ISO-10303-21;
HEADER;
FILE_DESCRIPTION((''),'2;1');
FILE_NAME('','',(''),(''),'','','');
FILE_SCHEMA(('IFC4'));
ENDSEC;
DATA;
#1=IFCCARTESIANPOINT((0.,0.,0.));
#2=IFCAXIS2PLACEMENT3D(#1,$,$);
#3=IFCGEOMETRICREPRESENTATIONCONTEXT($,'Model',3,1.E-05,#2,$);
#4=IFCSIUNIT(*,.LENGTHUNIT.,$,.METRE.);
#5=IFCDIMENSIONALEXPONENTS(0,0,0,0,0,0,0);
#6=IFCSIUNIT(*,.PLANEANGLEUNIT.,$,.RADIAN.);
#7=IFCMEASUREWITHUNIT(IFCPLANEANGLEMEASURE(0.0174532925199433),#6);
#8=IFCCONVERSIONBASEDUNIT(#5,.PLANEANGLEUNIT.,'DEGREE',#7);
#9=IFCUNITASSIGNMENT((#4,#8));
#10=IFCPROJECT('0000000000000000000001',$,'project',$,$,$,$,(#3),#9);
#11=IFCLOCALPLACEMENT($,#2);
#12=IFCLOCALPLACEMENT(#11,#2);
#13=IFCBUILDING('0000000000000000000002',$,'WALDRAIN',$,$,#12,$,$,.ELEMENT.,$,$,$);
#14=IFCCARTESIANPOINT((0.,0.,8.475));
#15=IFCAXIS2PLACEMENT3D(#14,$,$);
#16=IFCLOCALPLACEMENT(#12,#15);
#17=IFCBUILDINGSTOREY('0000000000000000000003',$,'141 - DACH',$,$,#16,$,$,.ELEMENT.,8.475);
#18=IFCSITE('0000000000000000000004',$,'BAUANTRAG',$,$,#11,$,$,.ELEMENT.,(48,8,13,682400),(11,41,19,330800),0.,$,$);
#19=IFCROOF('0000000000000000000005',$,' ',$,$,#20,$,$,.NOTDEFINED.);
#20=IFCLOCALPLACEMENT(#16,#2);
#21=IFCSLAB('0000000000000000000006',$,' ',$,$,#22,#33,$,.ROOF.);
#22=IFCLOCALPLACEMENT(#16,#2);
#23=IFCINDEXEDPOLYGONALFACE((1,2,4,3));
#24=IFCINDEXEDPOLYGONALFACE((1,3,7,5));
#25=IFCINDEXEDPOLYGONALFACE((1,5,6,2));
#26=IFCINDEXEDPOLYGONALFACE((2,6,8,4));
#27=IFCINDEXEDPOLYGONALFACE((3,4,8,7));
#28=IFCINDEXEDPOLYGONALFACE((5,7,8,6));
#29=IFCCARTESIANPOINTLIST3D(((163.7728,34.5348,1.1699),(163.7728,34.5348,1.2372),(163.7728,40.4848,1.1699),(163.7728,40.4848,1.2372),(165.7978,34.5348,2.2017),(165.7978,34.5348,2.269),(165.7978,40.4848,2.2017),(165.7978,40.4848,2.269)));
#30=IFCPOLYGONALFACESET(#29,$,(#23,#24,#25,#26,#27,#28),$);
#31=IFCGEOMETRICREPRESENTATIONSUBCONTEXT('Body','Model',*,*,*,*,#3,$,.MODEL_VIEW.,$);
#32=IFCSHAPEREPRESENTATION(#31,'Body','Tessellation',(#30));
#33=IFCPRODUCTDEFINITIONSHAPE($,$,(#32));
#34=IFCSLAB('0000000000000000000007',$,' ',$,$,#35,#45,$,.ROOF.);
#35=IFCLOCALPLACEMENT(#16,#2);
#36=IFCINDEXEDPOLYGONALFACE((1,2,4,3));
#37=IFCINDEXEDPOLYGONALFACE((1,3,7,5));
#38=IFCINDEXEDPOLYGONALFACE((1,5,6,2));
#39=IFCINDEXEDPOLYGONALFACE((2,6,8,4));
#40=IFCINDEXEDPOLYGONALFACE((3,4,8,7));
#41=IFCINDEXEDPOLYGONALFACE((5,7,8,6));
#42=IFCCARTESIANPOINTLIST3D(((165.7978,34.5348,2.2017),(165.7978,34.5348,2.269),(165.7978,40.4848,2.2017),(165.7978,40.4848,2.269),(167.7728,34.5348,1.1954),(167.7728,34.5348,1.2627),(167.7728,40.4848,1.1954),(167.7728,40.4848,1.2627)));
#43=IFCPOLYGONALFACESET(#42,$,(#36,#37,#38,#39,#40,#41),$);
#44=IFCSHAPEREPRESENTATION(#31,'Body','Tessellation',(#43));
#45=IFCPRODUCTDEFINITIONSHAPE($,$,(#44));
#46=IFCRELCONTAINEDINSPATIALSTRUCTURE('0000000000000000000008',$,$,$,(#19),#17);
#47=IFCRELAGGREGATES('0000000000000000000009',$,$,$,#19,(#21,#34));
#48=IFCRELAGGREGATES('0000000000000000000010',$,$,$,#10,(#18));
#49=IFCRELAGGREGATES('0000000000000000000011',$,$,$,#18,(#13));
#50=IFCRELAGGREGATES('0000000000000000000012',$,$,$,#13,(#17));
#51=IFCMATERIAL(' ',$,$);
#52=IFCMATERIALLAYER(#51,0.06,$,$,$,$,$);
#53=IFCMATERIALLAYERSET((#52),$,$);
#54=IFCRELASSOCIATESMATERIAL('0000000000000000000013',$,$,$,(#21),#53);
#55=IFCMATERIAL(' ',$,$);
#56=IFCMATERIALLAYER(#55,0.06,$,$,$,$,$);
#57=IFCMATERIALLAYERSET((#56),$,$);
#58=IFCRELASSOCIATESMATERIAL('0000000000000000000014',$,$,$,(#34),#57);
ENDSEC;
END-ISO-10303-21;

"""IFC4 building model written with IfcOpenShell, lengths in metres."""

from ifc_helpers import new_model, entity, si_unit, converted_unit, frame, frame_2d, origin, origin_2d_with_axis, place, context, subcontext, project, spatial, rectangle, extrude, material, layer, layer_set, layer_usage, element, aggregate, save


model = new_model("IFC4")

# Units and contexts
model_context = context("Model", 3, precision=1e-05, world=origin())
body_context = subcontext(model_context, "Body", "Model", "MODEL_VIEW")
ifc_project = project(units=[si_unit("LENGTHUNIT", "METRE"), converted_unit("PLANEANGLEUNIT", "DEGREE", entity("IfcPlaneAngleMeasure", 0.0174532925199433), si_unit("PLANEANGLEUNIT", "RADIAN"), dimensions=[0, 0, 0, 0, 0, 0, 0])], contexts=[model_context])

# Site, building, storey
site_placement = place(None, origin())
site = spatial("IfcSite", under=ifc_project, at=site_placement, Name="BAUANTRAG", CompositionType="ELEMENT", RefLatitude=(48, 8, 13, 682400), RefLongitude=(11, 41, 19, 330800), RefElevation=0.0)
building_placement = place(site_placement, origin())
building = spatial("IfcBuilding", under=site, at=building_placement, Name="WALDRAIN", CompositionType="ELEMENT")
storey_placement = place(building_placement, frame((0.0, 0.0, 8.475)))
storey = spatial("IfcBuildingStorey", under=building, at=storey_placement, Name="141 - DACH", CompositionType="ELEMENT", Elevation=8.475)

# Roof, slabs
roof_placement = place(storey_placement, frame((0.0, 0.0, -8.475)))
roof = element("IfcRoof", 1, at=roof_placement, inside=storey, Name=" ", PredefinedType="NOTDEFINED")
ifc_material_1 = material(Name=" ")
ifc_layer_1 = layer(ifc_material_1, 0.06)
ifc_layer_set_1 = layer_set([ifc_layer_1])
ifc_layer_usage_1 = layer_usage(ifc_layer_set_1, "AXIS3", "POSITIVE", 0.0)
slab_1_placement = place(roof_placement, frame((163.7728, 34.5348, 9.6449)))
slab_1 = element("IfcSlab", 2, at=slab_1_placement, material=ifc_layer_usage_1, Name=" ", PredefinedType="ROOF", context=body_context, shape_type="SweptSolid", body=[
    extrude(rectangle(XDim=5.95, YDim=2.2727, at=origin_2d_with_axis()), frame((1.0125, 2.975, 0.5159), z_axis=(-0.45399, 0.0, 0.891007), x_axis=(0.0, 1.0, 0.0)), (0.0, -0.45399, 0.891007), 0.0673),
])
ifc_material_2 = material(Name=" ")
ifc_layer_2 = layer(ifc_material_2, 0.06)
ifc_layer_set_2 = layer_set([ifc_layer_2])
ifc_layer_usage_2 = layer_usage(ifc_layer_set_2, "AXIS3", "POSITIVE", 0.0)
slab_2_placement = place(roof_placement, frame((165.7978, 34.5348, 9.6704)))
slab_2 = element("IfcSlab", 3, at=slab_2_placement, material=ifc_layer_usage_2, Name=" ", PredefinedType="ROOF", context=body_context, shape_type="SweptSolid", body=[
    extrude(rectangle(XDim=2.2166, YDim=5.95, at=frame_2d((0.0, 0.0), x_axis=(0.0, 1.0))), frame((0.9875, 2.975, 0.5032), z_axis=(0.45399, 0.0, 0.891007), x_axis=(0.0, -1.0, 0.0)), (0.0, -0.45399, 0.891007), 0.0673),
])
aggregate(roof, [slab_1, slab_2])

save(model, "model.ifc")
